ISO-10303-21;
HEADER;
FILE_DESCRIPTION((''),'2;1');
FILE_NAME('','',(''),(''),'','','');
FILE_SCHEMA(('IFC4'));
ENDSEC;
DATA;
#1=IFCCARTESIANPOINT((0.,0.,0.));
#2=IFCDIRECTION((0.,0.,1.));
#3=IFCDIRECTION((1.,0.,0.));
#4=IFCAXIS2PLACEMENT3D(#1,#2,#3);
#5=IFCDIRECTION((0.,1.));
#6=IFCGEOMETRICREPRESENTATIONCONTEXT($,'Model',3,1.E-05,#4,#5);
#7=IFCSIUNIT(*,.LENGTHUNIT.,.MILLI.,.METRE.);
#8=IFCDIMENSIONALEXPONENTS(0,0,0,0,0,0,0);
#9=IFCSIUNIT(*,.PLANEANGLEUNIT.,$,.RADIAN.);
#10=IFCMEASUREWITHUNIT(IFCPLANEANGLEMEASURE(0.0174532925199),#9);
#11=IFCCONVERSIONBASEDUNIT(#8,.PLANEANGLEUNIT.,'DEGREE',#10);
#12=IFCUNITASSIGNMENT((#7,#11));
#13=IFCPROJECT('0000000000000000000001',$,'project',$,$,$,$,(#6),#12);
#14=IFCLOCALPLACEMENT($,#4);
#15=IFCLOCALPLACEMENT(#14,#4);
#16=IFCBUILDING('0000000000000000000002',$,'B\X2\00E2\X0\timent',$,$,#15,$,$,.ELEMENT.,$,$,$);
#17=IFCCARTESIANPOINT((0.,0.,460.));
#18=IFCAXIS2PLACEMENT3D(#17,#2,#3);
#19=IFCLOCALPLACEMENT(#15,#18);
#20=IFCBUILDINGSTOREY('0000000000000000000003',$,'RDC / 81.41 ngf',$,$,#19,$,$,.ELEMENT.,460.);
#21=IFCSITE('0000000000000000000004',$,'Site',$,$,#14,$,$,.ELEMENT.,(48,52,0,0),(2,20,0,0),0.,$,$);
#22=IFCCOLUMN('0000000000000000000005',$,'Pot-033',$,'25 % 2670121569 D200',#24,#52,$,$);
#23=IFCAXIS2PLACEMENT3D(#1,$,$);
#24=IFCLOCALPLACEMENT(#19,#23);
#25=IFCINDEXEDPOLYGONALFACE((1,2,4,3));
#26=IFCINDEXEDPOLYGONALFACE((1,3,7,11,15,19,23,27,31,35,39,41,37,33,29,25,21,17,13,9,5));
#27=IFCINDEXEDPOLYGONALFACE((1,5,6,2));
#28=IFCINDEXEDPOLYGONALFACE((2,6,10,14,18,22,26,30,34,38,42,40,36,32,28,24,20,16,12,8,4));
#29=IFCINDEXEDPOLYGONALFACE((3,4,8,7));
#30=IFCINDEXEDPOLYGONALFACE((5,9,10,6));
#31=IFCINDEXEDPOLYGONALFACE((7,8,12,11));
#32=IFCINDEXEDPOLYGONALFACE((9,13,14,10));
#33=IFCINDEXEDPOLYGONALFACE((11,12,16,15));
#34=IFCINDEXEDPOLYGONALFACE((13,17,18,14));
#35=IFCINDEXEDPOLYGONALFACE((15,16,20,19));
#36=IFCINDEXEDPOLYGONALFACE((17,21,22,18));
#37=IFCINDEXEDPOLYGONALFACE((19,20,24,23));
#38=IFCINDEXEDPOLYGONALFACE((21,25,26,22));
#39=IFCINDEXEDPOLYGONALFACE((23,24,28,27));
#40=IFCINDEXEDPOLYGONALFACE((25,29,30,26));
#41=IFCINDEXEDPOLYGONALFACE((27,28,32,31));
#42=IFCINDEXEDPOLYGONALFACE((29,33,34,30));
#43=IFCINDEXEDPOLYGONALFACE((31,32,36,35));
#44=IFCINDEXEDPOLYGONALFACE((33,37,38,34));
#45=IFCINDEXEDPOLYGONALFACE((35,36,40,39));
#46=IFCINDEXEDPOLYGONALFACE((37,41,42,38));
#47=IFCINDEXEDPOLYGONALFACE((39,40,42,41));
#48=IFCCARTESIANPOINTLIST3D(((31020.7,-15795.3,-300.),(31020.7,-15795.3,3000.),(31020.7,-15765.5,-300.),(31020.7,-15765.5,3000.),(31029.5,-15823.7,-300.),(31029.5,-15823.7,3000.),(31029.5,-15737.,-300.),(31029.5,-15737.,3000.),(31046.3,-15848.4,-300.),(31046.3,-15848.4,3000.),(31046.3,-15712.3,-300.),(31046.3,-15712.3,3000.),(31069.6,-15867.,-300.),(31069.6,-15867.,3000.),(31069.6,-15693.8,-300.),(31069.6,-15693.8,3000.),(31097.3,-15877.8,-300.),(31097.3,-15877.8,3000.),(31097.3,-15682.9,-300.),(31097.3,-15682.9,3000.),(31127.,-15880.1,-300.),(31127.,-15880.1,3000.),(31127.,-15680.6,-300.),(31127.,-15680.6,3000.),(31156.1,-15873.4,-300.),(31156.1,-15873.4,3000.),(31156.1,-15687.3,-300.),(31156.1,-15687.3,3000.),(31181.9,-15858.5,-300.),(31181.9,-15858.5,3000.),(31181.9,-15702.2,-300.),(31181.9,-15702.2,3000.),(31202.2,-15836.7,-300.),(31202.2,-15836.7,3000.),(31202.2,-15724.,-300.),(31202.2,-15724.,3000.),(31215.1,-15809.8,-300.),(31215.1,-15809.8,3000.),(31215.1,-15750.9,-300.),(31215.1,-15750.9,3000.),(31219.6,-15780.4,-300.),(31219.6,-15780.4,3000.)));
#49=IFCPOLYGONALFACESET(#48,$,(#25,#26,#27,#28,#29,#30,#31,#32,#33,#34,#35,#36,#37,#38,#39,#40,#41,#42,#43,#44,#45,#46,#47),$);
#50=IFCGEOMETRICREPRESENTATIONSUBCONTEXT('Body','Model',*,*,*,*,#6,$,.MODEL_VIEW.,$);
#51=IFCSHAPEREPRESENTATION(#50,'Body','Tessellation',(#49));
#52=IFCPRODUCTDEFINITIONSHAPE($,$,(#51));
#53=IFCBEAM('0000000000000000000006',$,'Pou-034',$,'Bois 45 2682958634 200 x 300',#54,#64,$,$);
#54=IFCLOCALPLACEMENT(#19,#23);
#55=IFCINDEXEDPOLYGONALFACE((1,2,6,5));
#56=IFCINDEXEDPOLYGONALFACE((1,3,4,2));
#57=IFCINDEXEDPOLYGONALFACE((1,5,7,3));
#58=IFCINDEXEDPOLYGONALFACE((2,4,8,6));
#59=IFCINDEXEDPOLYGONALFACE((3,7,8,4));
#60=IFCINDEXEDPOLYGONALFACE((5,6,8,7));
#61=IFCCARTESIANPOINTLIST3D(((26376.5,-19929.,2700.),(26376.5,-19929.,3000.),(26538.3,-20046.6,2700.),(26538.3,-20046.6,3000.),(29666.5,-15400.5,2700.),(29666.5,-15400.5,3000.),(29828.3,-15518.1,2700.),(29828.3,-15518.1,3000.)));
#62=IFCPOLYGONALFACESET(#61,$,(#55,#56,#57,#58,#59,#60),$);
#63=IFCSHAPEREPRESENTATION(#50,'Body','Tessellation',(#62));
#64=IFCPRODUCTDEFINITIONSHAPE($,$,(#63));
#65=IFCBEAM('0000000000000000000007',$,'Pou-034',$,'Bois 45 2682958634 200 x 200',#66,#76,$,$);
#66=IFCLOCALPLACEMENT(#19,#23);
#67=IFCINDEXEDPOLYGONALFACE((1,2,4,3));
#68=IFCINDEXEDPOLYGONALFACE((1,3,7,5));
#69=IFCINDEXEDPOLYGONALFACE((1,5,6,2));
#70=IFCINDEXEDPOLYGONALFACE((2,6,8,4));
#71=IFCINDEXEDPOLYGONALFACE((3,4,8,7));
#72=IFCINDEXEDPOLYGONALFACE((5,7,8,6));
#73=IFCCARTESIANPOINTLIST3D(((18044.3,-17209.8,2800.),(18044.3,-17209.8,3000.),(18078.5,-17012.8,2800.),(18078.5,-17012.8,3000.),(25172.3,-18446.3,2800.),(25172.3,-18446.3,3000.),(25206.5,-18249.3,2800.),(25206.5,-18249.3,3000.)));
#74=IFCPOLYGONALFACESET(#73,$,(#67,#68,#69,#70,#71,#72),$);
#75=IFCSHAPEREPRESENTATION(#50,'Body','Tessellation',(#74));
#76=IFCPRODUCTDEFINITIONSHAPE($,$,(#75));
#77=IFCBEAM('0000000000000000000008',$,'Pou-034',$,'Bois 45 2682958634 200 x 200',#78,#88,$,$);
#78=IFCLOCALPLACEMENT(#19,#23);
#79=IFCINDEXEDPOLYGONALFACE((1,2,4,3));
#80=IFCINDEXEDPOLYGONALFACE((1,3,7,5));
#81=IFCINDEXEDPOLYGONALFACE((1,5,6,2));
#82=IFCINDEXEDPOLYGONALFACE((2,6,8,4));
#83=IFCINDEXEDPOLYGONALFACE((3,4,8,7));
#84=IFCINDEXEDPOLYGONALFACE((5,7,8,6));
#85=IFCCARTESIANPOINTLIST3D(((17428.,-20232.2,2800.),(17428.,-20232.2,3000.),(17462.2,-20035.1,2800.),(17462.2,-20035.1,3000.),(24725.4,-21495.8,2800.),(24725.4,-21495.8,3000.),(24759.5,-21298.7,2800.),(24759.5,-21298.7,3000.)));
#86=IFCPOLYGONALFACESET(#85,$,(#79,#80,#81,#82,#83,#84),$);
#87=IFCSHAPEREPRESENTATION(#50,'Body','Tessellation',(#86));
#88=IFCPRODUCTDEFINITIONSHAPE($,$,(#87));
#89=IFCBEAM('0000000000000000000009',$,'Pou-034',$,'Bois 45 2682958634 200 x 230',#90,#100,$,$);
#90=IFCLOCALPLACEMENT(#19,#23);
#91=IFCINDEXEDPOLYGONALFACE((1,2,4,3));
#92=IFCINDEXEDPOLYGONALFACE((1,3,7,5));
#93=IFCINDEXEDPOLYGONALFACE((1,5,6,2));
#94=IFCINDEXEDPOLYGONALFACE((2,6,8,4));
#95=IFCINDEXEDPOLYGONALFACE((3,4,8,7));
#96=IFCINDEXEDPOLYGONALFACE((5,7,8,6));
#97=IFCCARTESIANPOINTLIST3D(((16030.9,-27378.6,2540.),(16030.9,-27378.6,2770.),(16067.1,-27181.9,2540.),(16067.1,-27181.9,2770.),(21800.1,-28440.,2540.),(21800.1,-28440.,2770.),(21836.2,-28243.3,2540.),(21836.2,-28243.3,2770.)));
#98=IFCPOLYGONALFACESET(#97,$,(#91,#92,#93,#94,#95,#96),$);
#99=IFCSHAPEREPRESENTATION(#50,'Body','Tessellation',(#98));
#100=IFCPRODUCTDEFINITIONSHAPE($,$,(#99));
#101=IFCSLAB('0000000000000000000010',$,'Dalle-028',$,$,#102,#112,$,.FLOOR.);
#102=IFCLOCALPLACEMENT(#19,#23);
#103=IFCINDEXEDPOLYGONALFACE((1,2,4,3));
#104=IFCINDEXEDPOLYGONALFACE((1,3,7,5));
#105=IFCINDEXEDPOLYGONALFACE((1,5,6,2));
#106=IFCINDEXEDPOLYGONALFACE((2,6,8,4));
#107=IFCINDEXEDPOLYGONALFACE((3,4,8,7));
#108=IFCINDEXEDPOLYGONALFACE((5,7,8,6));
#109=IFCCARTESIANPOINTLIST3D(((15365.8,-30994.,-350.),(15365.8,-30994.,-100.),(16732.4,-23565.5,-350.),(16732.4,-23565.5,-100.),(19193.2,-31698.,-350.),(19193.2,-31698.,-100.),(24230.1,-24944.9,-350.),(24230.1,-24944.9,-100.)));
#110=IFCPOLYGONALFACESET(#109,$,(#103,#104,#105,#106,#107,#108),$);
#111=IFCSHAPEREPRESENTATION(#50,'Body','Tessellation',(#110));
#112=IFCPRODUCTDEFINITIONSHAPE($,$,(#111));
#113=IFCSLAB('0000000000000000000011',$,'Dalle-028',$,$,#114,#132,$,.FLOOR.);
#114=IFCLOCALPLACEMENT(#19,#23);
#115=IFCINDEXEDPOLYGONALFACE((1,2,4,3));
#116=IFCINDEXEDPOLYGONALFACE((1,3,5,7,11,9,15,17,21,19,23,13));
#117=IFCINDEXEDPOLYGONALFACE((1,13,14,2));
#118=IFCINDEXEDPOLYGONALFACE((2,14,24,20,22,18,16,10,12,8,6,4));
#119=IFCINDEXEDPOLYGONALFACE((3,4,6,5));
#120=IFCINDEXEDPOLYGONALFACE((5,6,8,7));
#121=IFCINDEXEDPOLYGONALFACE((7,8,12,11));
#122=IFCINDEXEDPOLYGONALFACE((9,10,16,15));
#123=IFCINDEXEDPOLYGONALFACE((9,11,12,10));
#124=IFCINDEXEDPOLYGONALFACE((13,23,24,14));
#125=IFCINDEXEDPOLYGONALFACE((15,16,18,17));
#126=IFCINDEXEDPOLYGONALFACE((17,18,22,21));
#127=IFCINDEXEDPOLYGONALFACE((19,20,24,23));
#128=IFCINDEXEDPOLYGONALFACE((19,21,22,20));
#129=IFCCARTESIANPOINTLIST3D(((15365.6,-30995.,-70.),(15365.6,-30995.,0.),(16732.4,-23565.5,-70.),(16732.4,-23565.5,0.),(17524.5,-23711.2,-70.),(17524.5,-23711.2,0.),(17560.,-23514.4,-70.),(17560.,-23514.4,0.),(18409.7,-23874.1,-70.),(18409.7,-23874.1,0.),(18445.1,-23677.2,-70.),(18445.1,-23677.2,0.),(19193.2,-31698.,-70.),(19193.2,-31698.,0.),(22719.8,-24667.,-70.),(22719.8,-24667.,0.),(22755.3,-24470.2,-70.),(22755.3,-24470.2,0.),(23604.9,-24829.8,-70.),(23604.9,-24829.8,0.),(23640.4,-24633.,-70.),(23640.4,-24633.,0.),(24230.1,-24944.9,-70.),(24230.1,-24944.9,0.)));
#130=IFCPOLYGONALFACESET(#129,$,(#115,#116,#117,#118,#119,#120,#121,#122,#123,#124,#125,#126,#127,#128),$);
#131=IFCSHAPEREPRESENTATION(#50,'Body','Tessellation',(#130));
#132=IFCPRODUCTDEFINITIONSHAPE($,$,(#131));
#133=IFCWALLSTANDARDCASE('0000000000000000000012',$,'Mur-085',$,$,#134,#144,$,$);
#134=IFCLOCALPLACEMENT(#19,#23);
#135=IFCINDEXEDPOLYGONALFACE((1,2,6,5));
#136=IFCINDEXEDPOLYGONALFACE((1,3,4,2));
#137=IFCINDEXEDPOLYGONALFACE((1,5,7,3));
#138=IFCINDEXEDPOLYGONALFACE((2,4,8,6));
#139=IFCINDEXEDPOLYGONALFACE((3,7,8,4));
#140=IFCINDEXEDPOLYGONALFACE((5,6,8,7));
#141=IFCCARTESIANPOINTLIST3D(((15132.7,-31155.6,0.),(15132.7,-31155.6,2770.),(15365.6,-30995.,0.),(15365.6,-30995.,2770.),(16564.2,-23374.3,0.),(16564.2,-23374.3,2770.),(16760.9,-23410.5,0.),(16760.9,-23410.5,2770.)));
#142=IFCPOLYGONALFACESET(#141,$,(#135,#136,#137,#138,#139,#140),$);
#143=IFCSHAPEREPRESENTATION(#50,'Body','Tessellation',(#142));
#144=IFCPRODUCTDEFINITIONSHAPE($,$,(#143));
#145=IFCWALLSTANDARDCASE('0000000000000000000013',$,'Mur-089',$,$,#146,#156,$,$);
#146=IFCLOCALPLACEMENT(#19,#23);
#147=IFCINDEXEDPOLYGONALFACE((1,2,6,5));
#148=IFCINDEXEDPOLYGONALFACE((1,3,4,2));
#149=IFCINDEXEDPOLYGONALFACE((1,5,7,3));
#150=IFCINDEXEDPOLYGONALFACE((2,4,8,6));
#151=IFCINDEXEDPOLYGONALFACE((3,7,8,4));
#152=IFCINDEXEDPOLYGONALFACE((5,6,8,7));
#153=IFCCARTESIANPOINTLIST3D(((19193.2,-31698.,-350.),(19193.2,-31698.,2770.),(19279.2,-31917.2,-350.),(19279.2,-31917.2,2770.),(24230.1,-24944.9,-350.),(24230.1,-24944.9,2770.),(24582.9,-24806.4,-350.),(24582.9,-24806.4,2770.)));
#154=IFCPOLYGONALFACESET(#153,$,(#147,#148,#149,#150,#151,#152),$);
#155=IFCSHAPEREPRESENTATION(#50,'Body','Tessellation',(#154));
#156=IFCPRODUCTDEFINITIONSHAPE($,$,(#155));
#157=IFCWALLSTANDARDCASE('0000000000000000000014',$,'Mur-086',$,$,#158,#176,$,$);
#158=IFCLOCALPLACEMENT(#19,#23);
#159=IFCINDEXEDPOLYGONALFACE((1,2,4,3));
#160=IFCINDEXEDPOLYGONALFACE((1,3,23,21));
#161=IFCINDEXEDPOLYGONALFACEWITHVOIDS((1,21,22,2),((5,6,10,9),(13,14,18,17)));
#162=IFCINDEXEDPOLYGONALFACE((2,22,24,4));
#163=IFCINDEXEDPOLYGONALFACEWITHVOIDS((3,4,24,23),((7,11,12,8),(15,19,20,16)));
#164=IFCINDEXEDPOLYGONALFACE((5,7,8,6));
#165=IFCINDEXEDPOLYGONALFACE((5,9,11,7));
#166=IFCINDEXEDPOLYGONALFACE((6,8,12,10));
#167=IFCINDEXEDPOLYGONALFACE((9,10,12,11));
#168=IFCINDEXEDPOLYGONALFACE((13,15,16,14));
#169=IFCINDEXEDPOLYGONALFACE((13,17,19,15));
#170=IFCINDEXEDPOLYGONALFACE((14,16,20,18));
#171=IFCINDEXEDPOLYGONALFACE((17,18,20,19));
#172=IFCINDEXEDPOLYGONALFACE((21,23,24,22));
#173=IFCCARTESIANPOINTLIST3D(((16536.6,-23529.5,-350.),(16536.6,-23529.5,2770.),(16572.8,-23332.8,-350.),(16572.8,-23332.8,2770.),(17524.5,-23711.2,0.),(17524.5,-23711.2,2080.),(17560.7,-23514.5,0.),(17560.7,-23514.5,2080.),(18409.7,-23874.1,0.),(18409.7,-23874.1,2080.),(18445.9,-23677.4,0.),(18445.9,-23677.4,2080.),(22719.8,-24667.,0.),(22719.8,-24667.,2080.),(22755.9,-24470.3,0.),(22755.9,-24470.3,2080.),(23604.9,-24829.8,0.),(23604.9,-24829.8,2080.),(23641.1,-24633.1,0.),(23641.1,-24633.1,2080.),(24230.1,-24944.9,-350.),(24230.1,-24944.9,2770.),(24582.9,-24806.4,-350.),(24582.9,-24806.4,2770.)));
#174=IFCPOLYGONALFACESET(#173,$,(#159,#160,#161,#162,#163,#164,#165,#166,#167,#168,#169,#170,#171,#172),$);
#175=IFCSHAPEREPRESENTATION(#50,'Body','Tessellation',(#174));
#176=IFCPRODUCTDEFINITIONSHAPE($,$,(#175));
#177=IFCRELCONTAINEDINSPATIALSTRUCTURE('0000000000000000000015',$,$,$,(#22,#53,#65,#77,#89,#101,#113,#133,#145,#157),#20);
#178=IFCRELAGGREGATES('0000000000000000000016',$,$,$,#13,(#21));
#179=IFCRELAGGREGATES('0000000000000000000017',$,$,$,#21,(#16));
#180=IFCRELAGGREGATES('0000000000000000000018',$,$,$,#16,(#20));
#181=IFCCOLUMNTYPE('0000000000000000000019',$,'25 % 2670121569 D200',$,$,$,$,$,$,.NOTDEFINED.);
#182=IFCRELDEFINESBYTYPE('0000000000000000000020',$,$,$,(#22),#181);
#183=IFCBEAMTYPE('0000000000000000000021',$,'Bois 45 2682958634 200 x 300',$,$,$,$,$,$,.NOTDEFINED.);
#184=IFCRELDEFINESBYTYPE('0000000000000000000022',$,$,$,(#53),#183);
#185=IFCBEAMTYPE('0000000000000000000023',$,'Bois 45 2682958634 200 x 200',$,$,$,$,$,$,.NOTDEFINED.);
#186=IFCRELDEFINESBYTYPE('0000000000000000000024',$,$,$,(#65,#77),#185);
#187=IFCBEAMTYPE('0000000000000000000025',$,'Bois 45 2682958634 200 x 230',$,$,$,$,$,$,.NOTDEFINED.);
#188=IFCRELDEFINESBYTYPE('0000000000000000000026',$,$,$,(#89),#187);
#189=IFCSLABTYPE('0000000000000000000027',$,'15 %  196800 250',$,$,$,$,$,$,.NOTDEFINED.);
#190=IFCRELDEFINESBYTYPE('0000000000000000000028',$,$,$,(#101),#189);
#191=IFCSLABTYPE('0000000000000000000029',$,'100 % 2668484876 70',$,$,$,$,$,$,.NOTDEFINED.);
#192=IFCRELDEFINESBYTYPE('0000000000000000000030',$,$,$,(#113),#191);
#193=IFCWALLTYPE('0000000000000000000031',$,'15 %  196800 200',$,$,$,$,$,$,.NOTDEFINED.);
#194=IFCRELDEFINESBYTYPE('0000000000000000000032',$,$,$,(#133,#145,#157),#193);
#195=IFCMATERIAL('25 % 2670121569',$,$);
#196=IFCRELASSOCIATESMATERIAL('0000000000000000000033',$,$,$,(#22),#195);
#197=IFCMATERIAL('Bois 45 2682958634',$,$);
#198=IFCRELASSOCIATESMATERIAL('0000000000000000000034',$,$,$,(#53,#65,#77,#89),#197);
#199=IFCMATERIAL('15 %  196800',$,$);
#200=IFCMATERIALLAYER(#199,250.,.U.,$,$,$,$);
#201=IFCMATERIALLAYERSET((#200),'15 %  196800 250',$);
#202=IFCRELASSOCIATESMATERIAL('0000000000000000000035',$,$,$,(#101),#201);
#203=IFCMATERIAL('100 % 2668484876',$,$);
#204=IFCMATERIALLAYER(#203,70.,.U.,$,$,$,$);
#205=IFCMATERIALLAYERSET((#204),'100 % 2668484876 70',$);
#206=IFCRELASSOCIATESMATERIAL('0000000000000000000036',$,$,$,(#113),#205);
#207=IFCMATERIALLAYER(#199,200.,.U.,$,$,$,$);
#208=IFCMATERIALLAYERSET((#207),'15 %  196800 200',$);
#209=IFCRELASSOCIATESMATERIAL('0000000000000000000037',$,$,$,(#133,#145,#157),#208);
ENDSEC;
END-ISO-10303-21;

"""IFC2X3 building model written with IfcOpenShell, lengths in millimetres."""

from ifc_helpers import new_model, entity, si_unit, converted_unit, direction, frame, frame_2d, origin_with_axes, origin_2d_with_axis, place, context, subcontext, project, spatial, polyline, rectangle, circle, outline, extrude, material, layer, layer_set, layer_usage, type_object, element, save


model = new_model("IFC2X3")

# Units and contexts
model_context = context("Model", 3, precision=1e-05, world=origin_with_axes(), true_north=direction((0.0, 1.0)))
body_context = subcontext(model_context, "Body", "Model", "MODEL_VIEW")
ifc_project = project(units=[si_unit("LENGTHUNIT", "METRE", prefix="MILLI"), converted_unit("PLANEANGLEUNIT", "DEGREE", entity("IfcPlaneAngleMeasure", 0.0174532925199), si_unit("PLANEANGLEUNIT", "RADIAN"), dimensions=[0, 0, 0, 0, 0, 0, 0])], contexts=[model_context])

# Site, building, storey
site_placement = place(None, origin_with_axes())
site = spatial("IfcSite", under=ifc_project, at=site_placement, Name="Site", CompositionType="ELEMENT", RefLatitude=(48, 52, 0, 0), RefLongitude=(2, 20, 0, 0), RefElevation=0.0)
building_placement = place(site_placement, origin_with_axes())
building = spatial("IfcBuilding", under=site, at=building_placement, Name="Bâtiment", CompositionType="ELEMENT")
storey_placement = place(building_placement, frame((0.0, 0.0, 460.0), z_axis=(0.0, 0.0, 1.0), x_axis=(1.0, 0.0, 0.0)))
storey = spatial("IfcBuildingStorey", under=building, at=storey_placement, Name="RDC / 81.41 ngf", CompositionType="ELEMENT", Elevation=460.0)

# Column
ifc_material_1 = material(Name="25 % 2670121569")
column_type = type_object("IfcColumnType", Name="25 % 2670121569 D200", PredefinedType="NOTDEFINED")
column_placement = place(storey_placement, frame((31119.6, -15780.4, -300.0), z_axis=(0.0, 0.0, 1.0), x_axis=(1.0, 0.0, 0.0)))
element("IfcColumn", 1, at=column_placement, inside=storey, type_object=column_type, material=ifc_material_1, Name="Pot-033", ObjectType="25 % 2670121569 D200", context=body_context, shape_type="SweptSolid", body=[
    extrude(circle(Radius=100.0, at=origin_2d_with_axis()), origin_with_axes(), (0.0, 0.0, 1.0), 3300.0),
])

# Beams
ifc_material_2 = material(Name="Bois 45 2682958634")
beam_type_1 = type_object("IfcBeamType", Name="Bois 45 2682958634 200 x 300", PredefinedType="NOTDEFINED")
beam_1_placement = place(storey_placement, frame((26457.4, -19987.8, 3000.0), z_axis=(0.0, 0.0, 1.0), x_axis=(0.809034, -0.587762, 0.0)))
element("IfcBeam", 2, at=beam_1_placement, inside=storey, type_object=beam_type_1, material=ifc_material_2, Name="Pou-034", ObjectType="Bois 45 2682958634 200 x 300", context=body_context, shape_type="SweptSolid", body=[
    extrude(rectangle(XDim=300.0, YDim=200.0, at=frame_2d((-150.0, 0.0), x_axis=(1.0, 0.0))), frame((0.0, 0.0, 0.0), z_axis=(0.0, 1.0, 0.0), x_axis=(0.0, 0.0, 1.0)), (0.0, 0.0, 1.0), 5597.4),
])
beam_type_2 = type_object("IfcBeamType", Name="Bois 45 2682958634 200 x 200", PredefinedType="NOTDEFINED")
beam_2_placement = place(storey_placement, frame((18061.4, -17111.3, 3000.0), z_axis=(0.0, 0.0, 1.0), x_axis=(-0.170918, -0.985285, 0.0)))
element("IfcBeam", 3, at=beam_2_placement, inside=storey, type_object=beam_type_2, material=ifc_material_2, Name="Pou-034", ObjectType="Bois 45 2682958634 200 x 200", context=body_context, shape_type="SweptSolid", body=[
    extrude(rectangle(XDim=200.0, YDim=200.0, at=frame_2d((-100.0, 0.0), x_axis=(1.0, 0.0))), frame((0.0, 0.0, 0.0), z_axis=(0.0, 1.0, 0.0), x_axis=(0.0, 0.0, 1.0)), (0.0, 0.0, 1.0), 7234.5),
])
beam_3_placement = place(storey_placement, frame((17445.1, -20133.6, 3000.0), z_axis=(0.0, 0.0, 1.0), x_axis=(-0.170616, -0.985338, 0.0)))
element("IfcBeam", 4, at=beam_3_placement, inside=storey, type_object=beam_type_2, material=ifc_material_2, Name="Pou-034", ObjectType="Bois 45 2682958634 200 x 200", context=body_context, shape_type="SweptSolid", body=[
    extrude(rectangle(XDim=200.0, YDim=200.0, at=frame_2d((-100.0, 0.0), x_axis=(1.0, 0.0))), frame((0.0, 0.0, 0.0), z_axis=(0.0, 1.0, 0.0), x_axis=(0.0, 0.0, 1.0)), (0.0, 0.0, 1.0), 7405.9),
])
beam_type_3 = type_object("IfcBeamType", Name="Bois 45 2682958634 200 x 230", PredefinedType="NOTDEFINED")
beam_4_placement = place(storey_placement, frame((16049.0, -27280.3, 2770.0), z_axis=(0.0, 0.0, 1.0), x_axis=(-0.180933, -0.983495, 0.0)))
element("IfcBeam", 5, at=beam_4_placement, inside=storey, type_object=beam_type_3, material=ifc_material_2, Name="Pou-034", ObjectType="Bois 45 2682958634 200 x 230", context=body_context, shape_type="SweptSolid", body=[
    extrude(rectangle(XDim=230.0, YDim=200.0, at=frame_2d((-115.0, 0.0), x_axis=(1.0, 0.0))), frame((0.0, 0.0, 0.0), z_axis=(0.0, 1.0, 0.0), x_axis=(0.0, 0.0, 1.0)), (0.0, 0.0, 1.0), 5866.0),
])

# Slabs
ifc_material_3 = material(Name="15 %  196800")
ifc_layer_1 = layer(ifc_material_3, 250.0, ventilated="UNKNOWN")
ifc_layer_set_1 = layer_set([ifc_layer_1], Name="15 %  196800 250")
ifc_layer_usage_1 = layer_usage(ifc_layer_set_1, "AXIS3", "NEGATIVE", 250.0)
slab_type_1 = type_object("IfcSlabType", Name="15 %  196800 250", PredefinedType="NOTDEFINED")
slab_1_placement = place(storey_placement, frame((16732.4, -23565.5, -100.0), z_axis=(0.0, 0.0, 1.0), x_axis=(1.0, 0.0, 0.0)))
element("IfcSlab", 6, at=slab_1_placement, inside=storey, type_object=slab_type_1, material=ifc_layer_usage_1, Name="Dalle-028", PredefinedType="FLOOR", context=body_context, shape_type="SweptSolid", body=[
    extrude(outline(polyline([(0.0, 0.0), (-1366.6, -7428.5), (2460.8, -8132.5), (7497.7, -1379.4), (0.0, 0.0)])), frame((0.0, 0.0, -250.0), z_axis=(0.0, 0.0, 1.0), x_axis=(1.0, 0.0, 0.0)), (0.0, 0.0, 1.0), 250.0),
])
ifc_material_4 = material(Name="100 % 2668484876")
ifc_layer_2 = layer(ifc_material_4, 70.0, ventilated="UNKNOWN")
ifc_layer_set_2 = layer_set([ifc_layer_2], Name="100 % 2668484876 70")
ifc_layer_usage_2 = layer_usage(ifc_layer_set_2, "AXIS3", "NEGATIVE", 70.0)
slab_type_2 = type_object("IfcSlabType", Name="100 % 2668484876 70", PredefinedType="NOTDEFINED")
slab_2_placement = place(storey_placement, frame((15365.6, -30995.0, 0.0), z_axis=(0.0, 0.0, 1.0), x_axis=(1.0, 0.0, 0.0)))
element("IfcSlab", 7, at=slab_2_placement, inside=storey, type_object=slab_type_2, material=ifc_layer_usage_2, Name="Dalle-028", PredefinedType="FLOOR", context=body_context, shape_type="SweptSolid", body=[
    extrude(outline(polyline([(0.0, 0.0), (3827.6, -703.0), (8864.6, 6050.2), (8239.3, 6165.2), (8274.8, 6362.0), (7389.7, 6524.9), (7354.2, 6328.0), (3044.1, 7121.0), (3079.5, 7317.8), (2194.4, 7480.6), (2158.9, 7283.8), (1366.8, 7429.5), (0.0, 0.0)])), frame((0.0, 0.0, -70.0), z_axis=(0.0, 0.0, 1.0), x_axis=(1.0, 0.0, 0.0)), (0.0, 0.0, 1.0), 70.0),
])

# Walls
ifc_layer_3 = layer(ifc_material_3, 200.0, ventilated="UNKNOWN")
ifc_layer_set_3 = layer_set([ifc_layer_3], Name="15 %  196800 200")
ifc_layer_usage_3 = layer_usage(ifc_layer_set_3, "AXIS2", "POSITIVE", -200.0)
wall_type_1 = type_object("IfcWallType", Name="15 %  196800 200", PredefinedType="NOTDEFINED")
wall_1_placement = place(storey_placement, frame((15168.9, -30958.9, 0.0), z_axis=(0.0, 0.0, 1.0), x_axis=(0.180933, 0.983495, 0.0)))
element("IfcWallStandardCase", 8, at=wall_1_placement, inside=storey, type_object=wall_type_1, material=ifc_layer_usage_3, Name="Mur-085", context=body_context, shape_type="SweptSolid", body=[
    extrude(outline(polyline([(0.1, -200.0), (7711.8, -200.0), (7711.8, 0.0), (-200.0, 0.0), (0.1, -200.0)])), origin_with_axes(), (0.0, 0.0, 1.0), 2770.0),
])
ifc_layer_usage_4 = layer_usage(ifc_layer_set_3, "AXIS2", "POSITIVE", -200.0)
wall_2_placement = place(storey_placement, frame((19193.2, -31698.0, -350.0), z_axis=(0.0, 0.0, 1.0), x_axis=(0.597879, 0.801586, 0.0)))
element("IfcWallStandardCase", 9, at=wall_2_placement, inside=storey, type_object=wall_type_1, material=ifc_layer_usage_4, Name="Mur-089", context=body_context, shape_type="SweptSolid", body=[
    extrude(outline(polyline([(-124.2, -200.0), (8746.7, -200.0), (8424.8, 0.0), (0.0, 0.0), (-124.2, -200.0)])), origin_with_axes(), (0.0, 0.0, 1.0), 3120.0),
])

# Wall, openings
ifc_layer_usage_5 = layer_usage(ifc_layer_set_3, "AXIS2", "POSITIVE", -200.0)
wall_3_placement = place(storey_placement, frame((16572.8, -23332.8, -350.0), z_axis=(0.0, 0.0, 1.0), x_axis=(0.983495, -0.180933, 0.0)))
wall_3 = element("IfcWallStandardCase", 10, at=wall_3_placement, inside=storey, type_object=wall_type_1, material=ifc_layer_usage_5, Name="Mur-086", context=body_context, shape_type="SweptSolid", body=[
    extrude(outline(polyline([(0.0, -200.0), (7822.6, -200.0), (8144.5, 0.0), (0.0, 0.0), (0.0, -200.0)])), origin_with_axes(), (0.0, 0.0, 1.0), 3120.0),
])
opening_1_placement = place(wall_3_placement, frame((1454.5, 0.0, 350.0), z_axis=(0.0, 0.0, 1.0), x_axis=(1.0, 0.0, 0.0)))
element("IfcOpeningElement", 11, at=opening_1_placement, cuts=wall_3, context=body_context, shape_type="SweptSolid", body=[
    extrude(rectangle(XDim=900.0, YDim=2080.0, at=origin_2d_with_axis()), frame((0.0, 200.0, 1040.0), z_axis=(0.0, -1.0, 0.0), x_axis=(1.0, 0.0, 0.0)), (0.0, 0.0, 1.0), 600.0),
])
opening_2_placement = place(wall_3_placement, frame((6736.9, 0.0, 350.0), z_axis=(0.0, 0.0, 1.0), x_axis=(1.0, 0.0, 0.0)))
element("IfcOpeningElement", 12, at=opening_2_placement, cuts=wall_3, context=body_context, shape_type="SweptSolid", body=[
    extrude(rectangle(XDim=900.0, YDim=2080.0, at=origin_2d_with_axis()), frame((0.0, 200.0, 1040.0), z_axis=(0.0, -1.0, 0.0), x_axis=(1.0, 0.0, 0.0)), (0.0, 0.0, 1.0), 600.0),
])

save(model, "model.ifc")
